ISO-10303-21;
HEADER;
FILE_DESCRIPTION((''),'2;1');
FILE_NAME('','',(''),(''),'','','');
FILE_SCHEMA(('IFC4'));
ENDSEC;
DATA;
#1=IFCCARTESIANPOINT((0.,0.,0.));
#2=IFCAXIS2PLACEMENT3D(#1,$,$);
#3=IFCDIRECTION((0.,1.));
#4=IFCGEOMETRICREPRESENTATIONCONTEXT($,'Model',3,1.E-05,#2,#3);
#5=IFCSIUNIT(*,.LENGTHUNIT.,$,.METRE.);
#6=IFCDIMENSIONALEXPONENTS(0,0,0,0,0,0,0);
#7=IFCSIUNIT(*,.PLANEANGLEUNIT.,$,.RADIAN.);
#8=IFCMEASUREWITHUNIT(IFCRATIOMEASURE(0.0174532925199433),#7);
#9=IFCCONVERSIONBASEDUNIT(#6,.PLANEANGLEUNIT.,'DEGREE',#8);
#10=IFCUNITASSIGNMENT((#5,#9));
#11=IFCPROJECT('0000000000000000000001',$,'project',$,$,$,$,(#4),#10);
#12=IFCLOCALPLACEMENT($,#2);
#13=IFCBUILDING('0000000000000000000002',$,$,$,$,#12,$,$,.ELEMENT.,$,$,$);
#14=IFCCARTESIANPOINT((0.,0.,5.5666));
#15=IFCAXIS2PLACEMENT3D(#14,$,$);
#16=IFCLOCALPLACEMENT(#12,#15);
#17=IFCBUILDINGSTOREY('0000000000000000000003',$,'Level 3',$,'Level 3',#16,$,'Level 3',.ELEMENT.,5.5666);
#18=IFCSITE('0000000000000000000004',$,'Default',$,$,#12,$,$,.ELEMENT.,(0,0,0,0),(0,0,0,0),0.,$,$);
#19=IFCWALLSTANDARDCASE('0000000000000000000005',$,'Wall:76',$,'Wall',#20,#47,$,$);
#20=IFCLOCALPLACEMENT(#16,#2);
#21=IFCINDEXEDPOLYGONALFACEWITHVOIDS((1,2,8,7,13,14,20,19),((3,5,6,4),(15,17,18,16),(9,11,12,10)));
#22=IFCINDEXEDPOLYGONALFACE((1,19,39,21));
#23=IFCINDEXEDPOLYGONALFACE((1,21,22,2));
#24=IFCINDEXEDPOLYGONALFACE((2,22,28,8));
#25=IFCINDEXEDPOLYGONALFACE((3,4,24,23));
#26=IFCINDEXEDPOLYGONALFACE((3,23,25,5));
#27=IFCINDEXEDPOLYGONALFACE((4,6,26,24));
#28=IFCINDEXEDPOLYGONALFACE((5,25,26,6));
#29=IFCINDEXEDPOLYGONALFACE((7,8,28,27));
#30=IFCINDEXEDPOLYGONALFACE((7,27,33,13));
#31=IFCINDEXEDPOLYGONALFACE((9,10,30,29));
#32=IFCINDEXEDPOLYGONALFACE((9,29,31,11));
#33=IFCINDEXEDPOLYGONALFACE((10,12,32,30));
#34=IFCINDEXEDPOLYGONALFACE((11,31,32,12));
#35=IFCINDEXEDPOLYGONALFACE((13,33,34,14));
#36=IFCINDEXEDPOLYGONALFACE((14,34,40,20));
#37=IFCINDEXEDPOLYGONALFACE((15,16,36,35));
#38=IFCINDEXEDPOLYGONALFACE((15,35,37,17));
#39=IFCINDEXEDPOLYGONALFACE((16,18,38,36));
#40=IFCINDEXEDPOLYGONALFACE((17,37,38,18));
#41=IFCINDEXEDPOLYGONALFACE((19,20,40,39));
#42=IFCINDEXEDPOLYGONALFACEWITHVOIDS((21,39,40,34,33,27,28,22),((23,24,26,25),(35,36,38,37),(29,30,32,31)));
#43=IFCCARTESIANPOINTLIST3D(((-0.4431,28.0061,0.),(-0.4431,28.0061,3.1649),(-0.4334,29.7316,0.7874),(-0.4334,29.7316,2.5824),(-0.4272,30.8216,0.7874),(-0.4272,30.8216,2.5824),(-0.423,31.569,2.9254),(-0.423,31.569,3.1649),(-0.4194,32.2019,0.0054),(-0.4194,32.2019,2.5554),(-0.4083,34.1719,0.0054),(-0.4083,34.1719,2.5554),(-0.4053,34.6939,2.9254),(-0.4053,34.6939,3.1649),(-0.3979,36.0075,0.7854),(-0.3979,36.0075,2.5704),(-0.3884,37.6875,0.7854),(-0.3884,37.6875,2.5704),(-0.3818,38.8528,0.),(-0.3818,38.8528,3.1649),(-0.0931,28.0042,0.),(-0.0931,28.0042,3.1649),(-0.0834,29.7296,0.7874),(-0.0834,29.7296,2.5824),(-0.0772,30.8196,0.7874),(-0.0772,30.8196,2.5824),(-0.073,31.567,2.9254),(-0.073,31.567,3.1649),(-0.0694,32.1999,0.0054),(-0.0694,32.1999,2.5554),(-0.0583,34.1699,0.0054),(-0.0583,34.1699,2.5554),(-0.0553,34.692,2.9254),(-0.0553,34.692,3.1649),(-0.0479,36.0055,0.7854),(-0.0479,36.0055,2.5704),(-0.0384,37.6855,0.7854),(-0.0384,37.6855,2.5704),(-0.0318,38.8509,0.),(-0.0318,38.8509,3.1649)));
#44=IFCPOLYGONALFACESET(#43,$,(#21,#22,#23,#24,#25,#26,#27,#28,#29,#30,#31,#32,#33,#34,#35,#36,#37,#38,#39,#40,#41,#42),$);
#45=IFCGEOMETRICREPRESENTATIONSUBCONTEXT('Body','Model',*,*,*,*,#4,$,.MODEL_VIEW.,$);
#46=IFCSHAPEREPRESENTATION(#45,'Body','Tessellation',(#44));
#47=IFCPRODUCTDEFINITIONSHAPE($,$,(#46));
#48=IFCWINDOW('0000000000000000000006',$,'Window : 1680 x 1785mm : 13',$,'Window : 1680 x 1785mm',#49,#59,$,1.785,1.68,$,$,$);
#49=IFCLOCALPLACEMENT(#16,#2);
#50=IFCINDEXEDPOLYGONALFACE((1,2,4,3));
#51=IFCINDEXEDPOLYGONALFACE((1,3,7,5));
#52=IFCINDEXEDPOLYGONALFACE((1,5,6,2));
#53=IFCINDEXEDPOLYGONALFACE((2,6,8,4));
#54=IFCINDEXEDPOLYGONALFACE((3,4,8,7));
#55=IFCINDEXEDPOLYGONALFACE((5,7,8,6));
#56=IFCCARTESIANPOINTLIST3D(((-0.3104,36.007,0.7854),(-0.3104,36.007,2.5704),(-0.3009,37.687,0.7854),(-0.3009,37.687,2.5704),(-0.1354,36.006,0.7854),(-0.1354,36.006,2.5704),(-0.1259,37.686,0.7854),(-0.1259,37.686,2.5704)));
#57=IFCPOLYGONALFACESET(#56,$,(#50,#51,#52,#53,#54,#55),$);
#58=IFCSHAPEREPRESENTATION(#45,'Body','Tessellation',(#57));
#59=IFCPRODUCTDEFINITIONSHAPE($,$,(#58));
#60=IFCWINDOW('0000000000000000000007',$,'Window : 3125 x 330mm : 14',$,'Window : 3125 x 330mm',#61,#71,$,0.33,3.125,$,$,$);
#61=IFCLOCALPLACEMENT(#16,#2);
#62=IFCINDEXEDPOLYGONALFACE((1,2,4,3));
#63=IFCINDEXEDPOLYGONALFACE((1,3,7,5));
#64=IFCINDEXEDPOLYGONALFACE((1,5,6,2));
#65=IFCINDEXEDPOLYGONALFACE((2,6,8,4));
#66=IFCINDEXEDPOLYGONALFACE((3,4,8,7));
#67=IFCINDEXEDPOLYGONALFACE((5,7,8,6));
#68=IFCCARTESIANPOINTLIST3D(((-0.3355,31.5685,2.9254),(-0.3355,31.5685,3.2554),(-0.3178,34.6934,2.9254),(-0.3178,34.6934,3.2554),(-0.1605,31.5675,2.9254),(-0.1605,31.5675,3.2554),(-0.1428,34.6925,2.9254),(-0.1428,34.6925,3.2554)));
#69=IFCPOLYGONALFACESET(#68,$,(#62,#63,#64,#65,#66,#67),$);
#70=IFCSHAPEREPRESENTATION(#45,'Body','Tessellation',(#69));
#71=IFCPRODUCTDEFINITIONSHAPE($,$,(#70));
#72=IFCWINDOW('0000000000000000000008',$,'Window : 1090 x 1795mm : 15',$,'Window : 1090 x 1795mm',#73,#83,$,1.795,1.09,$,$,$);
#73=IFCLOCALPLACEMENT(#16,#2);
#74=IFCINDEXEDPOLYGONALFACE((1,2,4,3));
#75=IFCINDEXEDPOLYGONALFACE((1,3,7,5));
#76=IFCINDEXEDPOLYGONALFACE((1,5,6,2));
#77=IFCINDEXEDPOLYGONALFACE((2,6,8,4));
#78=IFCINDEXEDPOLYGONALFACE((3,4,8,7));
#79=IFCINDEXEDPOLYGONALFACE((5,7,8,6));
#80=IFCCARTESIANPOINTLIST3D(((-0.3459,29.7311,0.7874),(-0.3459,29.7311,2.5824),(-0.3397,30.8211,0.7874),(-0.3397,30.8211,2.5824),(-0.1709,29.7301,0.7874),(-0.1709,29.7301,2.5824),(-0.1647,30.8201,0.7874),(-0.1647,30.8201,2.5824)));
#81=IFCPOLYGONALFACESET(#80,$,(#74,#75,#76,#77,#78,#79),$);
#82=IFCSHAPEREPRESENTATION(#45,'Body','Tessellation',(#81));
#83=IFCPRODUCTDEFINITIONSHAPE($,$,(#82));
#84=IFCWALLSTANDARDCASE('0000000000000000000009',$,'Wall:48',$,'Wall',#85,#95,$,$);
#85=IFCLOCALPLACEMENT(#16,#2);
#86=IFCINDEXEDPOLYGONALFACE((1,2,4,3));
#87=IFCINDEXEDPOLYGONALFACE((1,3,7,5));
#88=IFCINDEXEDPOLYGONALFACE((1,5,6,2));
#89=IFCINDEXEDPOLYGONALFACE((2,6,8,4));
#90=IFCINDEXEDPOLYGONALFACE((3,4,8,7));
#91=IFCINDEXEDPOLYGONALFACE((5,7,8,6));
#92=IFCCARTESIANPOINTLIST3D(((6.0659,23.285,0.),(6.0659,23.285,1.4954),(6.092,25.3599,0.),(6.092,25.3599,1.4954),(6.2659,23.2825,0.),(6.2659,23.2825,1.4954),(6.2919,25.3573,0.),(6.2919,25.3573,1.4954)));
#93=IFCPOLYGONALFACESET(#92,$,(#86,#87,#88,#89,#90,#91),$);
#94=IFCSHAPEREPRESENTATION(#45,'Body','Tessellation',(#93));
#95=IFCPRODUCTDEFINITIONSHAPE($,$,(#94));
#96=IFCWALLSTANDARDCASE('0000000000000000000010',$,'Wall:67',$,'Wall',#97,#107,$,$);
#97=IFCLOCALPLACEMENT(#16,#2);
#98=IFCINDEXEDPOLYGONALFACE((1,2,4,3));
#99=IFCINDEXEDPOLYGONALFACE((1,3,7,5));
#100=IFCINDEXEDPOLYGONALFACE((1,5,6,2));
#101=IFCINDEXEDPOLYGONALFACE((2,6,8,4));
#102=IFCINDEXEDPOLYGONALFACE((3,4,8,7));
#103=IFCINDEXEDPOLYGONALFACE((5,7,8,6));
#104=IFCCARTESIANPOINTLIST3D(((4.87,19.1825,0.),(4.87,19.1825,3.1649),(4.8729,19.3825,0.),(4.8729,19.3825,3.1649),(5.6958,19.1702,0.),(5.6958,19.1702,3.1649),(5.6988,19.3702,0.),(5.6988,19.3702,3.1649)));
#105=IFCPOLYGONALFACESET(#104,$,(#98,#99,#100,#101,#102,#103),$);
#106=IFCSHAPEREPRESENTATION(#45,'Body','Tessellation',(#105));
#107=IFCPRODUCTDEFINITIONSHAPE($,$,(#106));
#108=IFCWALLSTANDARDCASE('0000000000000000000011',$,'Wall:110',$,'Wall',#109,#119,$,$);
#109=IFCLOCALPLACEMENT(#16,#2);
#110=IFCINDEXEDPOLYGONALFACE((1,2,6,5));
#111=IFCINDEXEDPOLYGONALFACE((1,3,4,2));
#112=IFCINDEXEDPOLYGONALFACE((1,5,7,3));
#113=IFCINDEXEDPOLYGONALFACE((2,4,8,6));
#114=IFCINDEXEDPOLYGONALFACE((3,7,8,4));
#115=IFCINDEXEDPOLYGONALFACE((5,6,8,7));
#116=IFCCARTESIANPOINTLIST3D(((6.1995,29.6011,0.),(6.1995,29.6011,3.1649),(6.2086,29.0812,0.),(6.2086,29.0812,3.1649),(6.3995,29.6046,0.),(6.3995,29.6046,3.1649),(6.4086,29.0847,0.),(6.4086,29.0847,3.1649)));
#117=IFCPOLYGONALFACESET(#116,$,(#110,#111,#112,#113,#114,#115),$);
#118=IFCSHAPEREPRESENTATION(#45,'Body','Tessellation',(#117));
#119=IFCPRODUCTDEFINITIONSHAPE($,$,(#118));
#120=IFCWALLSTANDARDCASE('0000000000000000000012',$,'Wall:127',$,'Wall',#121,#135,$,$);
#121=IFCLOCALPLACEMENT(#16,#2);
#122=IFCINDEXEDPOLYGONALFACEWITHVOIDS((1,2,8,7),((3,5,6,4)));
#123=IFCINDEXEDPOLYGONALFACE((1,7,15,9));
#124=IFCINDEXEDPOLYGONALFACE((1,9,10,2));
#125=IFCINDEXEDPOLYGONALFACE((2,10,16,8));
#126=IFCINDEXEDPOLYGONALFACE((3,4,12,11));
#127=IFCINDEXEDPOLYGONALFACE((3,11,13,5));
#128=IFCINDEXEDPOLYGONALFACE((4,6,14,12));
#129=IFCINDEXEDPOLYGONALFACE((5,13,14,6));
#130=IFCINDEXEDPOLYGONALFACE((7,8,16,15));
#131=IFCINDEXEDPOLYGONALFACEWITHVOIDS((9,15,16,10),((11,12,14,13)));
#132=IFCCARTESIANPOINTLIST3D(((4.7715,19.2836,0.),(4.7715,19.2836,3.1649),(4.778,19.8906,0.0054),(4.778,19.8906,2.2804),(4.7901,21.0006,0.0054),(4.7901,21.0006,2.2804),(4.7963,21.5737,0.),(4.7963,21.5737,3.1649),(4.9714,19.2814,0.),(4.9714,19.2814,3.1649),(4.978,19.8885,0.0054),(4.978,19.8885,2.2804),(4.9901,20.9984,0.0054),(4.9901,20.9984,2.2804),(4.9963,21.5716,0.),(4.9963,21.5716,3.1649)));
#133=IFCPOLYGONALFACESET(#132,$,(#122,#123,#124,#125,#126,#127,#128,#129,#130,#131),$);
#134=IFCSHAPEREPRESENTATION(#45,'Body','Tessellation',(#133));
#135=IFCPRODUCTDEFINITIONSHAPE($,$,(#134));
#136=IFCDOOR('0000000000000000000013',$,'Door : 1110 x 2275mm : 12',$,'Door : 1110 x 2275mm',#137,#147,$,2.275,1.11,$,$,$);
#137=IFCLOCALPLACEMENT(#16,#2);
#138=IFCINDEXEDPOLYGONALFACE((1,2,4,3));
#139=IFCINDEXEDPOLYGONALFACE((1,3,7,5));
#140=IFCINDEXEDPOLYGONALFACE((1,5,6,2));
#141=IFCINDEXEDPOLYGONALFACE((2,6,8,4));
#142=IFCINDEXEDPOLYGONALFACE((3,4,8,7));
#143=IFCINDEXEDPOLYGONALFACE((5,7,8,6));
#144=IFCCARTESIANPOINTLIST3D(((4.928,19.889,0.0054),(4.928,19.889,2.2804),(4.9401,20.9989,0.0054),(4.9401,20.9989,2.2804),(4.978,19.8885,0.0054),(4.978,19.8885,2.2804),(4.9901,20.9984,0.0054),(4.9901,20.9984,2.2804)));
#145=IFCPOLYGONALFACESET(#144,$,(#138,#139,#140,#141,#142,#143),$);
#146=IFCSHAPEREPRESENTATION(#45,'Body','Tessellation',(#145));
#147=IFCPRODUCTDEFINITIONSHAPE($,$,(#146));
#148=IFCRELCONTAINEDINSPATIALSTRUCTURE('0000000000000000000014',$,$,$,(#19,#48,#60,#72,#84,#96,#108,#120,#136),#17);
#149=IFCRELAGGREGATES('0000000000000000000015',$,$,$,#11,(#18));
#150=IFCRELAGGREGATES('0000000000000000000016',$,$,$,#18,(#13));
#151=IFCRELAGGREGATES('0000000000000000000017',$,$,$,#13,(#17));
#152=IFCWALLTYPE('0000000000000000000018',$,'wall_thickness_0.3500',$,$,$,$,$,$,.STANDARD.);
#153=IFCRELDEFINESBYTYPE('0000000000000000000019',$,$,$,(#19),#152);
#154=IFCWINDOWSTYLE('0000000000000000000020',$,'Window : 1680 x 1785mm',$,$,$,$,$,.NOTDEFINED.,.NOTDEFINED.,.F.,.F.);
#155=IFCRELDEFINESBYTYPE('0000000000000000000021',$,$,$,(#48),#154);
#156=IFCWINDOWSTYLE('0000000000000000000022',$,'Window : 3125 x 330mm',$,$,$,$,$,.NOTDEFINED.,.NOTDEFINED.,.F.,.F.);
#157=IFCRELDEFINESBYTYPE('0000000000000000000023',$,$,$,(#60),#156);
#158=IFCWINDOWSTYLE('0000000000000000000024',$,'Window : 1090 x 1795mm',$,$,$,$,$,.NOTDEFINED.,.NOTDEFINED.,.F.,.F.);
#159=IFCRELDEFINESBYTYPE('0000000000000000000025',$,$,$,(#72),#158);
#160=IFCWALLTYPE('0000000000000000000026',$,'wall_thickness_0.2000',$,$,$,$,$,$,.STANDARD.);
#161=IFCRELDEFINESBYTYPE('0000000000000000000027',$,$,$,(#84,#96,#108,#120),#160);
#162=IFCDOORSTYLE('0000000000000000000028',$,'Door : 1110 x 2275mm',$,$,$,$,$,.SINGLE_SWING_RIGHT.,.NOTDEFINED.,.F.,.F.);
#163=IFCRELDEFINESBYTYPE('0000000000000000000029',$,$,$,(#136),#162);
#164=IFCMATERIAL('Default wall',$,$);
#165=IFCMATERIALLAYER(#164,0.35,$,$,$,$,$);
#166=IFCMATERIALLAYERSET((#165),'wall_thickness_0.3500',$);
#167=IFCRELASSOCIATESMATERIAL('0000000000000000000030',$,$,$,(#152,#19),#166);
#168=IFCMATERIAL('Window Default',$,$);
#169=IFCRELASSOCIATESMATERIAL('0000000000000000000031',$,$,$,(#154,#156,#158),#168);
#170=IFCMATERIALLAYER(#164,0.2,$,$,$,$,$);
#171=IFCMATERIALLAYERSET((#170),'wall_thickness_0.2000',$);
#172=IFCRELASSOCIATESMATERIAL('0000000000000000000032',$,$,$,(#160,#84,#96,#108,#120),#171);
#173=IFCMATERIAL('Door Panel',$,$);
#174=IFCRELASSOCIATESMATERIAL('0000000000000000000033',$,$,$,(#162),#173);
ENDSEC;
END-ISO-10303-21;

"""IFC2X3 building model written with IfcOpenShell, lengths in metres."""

from ifc_helpers import new_model, entity, si_unit, converted_unit, direction, frame, frame_2d, origin, origin_2d_with_axis, place, context, subcontext, project, spatial, polyline, rectangle, outline, extrude, source, transform, mapped, material, layer, layer_set, layer_usage, type_object, type_shapes, element, fill, save


model = new_model("IFC2X3")

# Units and contexts
model_context = context("Model", 3, precision=1e-05, world=origin(), true_north=direction((0.0, 1.0)))
body_context = subcontext(model_context, "Body", "Model", "MODEL_VIEW")
ifc_project = project(units=[si_unit("LENGTHUNIT", "METRE"), converted_unit("PLANEANGLEUNIT", "DEGREE", entity("IfcRatioMeasure", 0.0174532925199433), si_unit("PLANEANGLEUNIT", "RADIAN"), dimensions=[0, 0, 0, 0, 0, 0, 0])], contexts=[model_context])

# Site, building, storey
placement_1 = place(None, origin())
site = spatial("IfcSite", under=ifc_project, at=placement_1, Name="Default", CompositionType="ELEMENT", RefLatitude=(0, 0, 0, 0), RefLongitude=(0, 0, 0, 0), RefElevation=0.0)
building = spatial("IfcBuilding", under=site, at=placement_1, CompositionType="ELEMENT")
storey_placement = place(placement_1, frame((0.0, 0.0, 5.5666)))
storey = spatial("IfcBuildingStorey", under=building, at=storey_placement, Name="Level 3", ObjectType="Level 3", LongName="Level 3", CompositionType="ELEMENT", Elevation=5.5666)

# Shared definitions
ifc_material_1 = material(Name="Default wall")
ifc_material_2 = material(Name="Door Panel")

# Wall, openings, windows
ifc_layer_1 = layer(ifc_material_1, 0.35)
ifc_layer_set_1 = layer_set([ifc_layer_1], Name="wall_thickness_0.3500")
ifc_layer_usage_1 = layer_usage(ifc_layer_set_1, "AXIS2", "POSITIVE", -0.175)
wall_type_1 = type_object("IfcWallType", Name="wall_thickness_0.3500", PredefinedType="STANDARD", material=ifc_layer_set_1)
wall_1_placement = place(storey_placement, frame((-0.2068, 38.8518, 0.0), z_axis=(0.0, 0.0, 1.0), x_axis=(-0.005654, -0.999984, 0.0)))
wall_1 = element("IfcWallStandardCase", 1, at=wall_1_placement, inside=storey, type_object=wall_type_1, material=ifc_layer_usage_1, Name="Wall:76", ObjectType="Wall", context=body_context, shape_type="SweptSolid", body=[
    extrude(outline(polyline([(10.8469, -0.175), (10.8469, 0.175), (0.0, 0.175), (0.0, -0.175), (10.8469, -0.175)])), origin(), (0.0, 0.0, 1.0), 3.1649),
])
opening_1_placement = place(wall_1_placement, frame((4.681, -0.175, 0.0054)))
element("IfcOpeningElement", 2, at=opening_1_placement, cuts=wall_1, ObjectType="Opening", context=body_context, shape_type="SweptSolid", body=[
    extrude(rectangle(XDim=1.97, YDim=2.55, at=frame_2d((1.275, 0.985), x_axis=(0.0, 1.0))), frame((0.0, 0.0, 0.0), z_axis=(0.0, 1.0, 0.0), x_axis=(0.0, 0.0, 1.0)), (0.0, 0.0, 1.0), 0.35),
])
opening_2_placement = place(wall_1_placement, frame((1.1654, -0.175, 0.7854)))
opening_2 = element("IfcOpeningElement", 3, at=opening_2_placement, cuts=wall_1, ObjectType="Opening", context=body_context, shape_type="SweptSolid", body=[
    extrude(rectangle(XDim=1.68, YDim=1.785, at=frame_2d((0.8925, 0.84), x_axis=(0.0, 1.0))), frame((0.0, 0.0, 0.0), z_axis=(0.0, 1.0, 0.0), x_axis=(0.0, 0.0, 1.0)), (0.0, 0.0, 1.0), 0.35),
])
opening_3_placement = place(wall_1_placement, frame((4.159, -0.175, 2.9254)))
opening_3 = element("IfcOpeningElement", 4, at=opening_3_placement, cuts=wall_1, ObjectType="Opening", context=body_context, shape_type="SweptSolid", body=[
    extrude(rectangle(XDim=3.125, YDim=0.33, at=frame_2d((0.165, 1.5625), x_axis=(0.0, 1.0))), frame((0.0, 0.0, 0.0), z_axis=(0.0, 1.0, 0.0), x_axis=(0.0, 0.0, 1.0)), (0.0, 0.0, 1.0), 0.35),
])
opening_4_placement = place(wall_1_placement, frame((8.0314, -0.175, 0.7874)))
opening_4 = element("IfcOpeningElement", 5, at=opening_4_placement, cuts=wall_1, ObjectType="Opening", context=body_context, shape_type="SweptSolid", body=[
    extrude(rectangle(XDim=1.09, YDim=1.795, at=frame_2d((0.8975, 0.545), x_axis=(0.0, 1.0))), frame((0.0, 0.0, 0.0), z_axis=(0.0, 1.0, 0.0), x_axis=(0.0, 0.0, 1.0)), (0.0, 0.0, 1.0), 0.35),
])
ifc_material_3 = material(Name="Window Default")
window_style_1 = type_object("IfcWindowStyle", Name="Window : 1680 x 1785mm", ConstructionType="NOTDEFINED", OperationType="NOTDEFINED", ParameterTakesPrecedence=False, Sizeable=False, material=ifc_material_3)
shared_shape_1 = source(origin(), body_context, "Body", "SweptSolid", [
    extrude(rectangle(XDim=0.175, YDim=1.68, at=origin_2d_with_axis()), frame((0.84, 0.175, 0.0), z_axis=(0.0, 0.0, 1.0), x_axis=(0.0, 1.0, 0.0)), (0.0, 0.0, 1.0), 1.785),
])
type_shapes(window_style_1, [shared_shape_1])
window_1_placement = place(opening_2_placement, origin())
window_1 = element("IfcWindow", 6, at=window_1_placement, inside=storey, type_object=window_style_1, Name="Window : 1680 x 1785mm : 13", ObjectType="Window : 1680 x 1785mm", OverallHeight=1.785, OverallWidth=1.68, context=body_context, shape_type="MappedRepresentation", body=[
    mapped(shared_shape_1, transform((0.0, 0.0, 0.0), scale=1.0)),
])
fill(opening_2, window_1)
window_style_2 = type_object("IfcWindowStyle", Name="Window : 3125 x 330mm", ConstructionType="NOTDEFINED", OperationType="NOTDEFINED", ParameterTakesPrecedence=False, Sizeable=False, material=ifc_material_3)
shared_shape_2 = source(origin(), body_context, "Body", "SweptSolid", [
    extrude(rectangle(XDim=0.175, YDim=3.125, at=origin_2d_with_axis()), frame((1.5625, 0.175, 0.0), z_axis=(0.0, 0.0, 1.0), x_axis=(0.0, 1.0, 0.0)), (0.0, 0.0, 1.0), 0.33),
])
type_shapes(window_style_2, [shared_shape_2])
window_2_placement = place(opening_3_placement, origin())
window_2 = element("IfcWindow", 7, at=window_2_placement, inside=storey, type_object=window_style_2, Name="Window : 3125 x 330mm : 14", ObjectType="Window : 3125 x 330mm", OverallHeight=0.33, OverallWidth=3.125, context=body_context, shape_type="MappedRepresentation", body=[
    mapped(shared_shape_2, transform((0.0, 0.0, 0.0), scale=1.0)),
])
fill(opening_3, window_2)
window_style_3 = type_object("IfcWindowStyle", Name="Window : 1090 x 1795mm", ConstructionType="NOTDEFINED", OperationType="NOTDEFINED", ParameterTakesPrecedence=False, Sizeable=False, material=ifc_material_3)
shared_shape_3 = source(origin(), body_context, "Body", "SweptSolid", [
    extrude(rectangle(XDim=0.175, YDim=1.09, at=origin_2d_with_axis()), frame((0.545, 0.175, 0.0), z_axis=(0.0, 0.0, 1.0), x_axis=(0.0, 1.0, 0.0)), (0.0, 0.0, 1.0), 1.795),
])
type_shapes(window_style_3, [shared_shape_3])
window_3_placement = place(opening_4_placement, origin())
window_3 = element("IfcWindow", 8, at=window_3_placement, inside=storey, type_object=window_style_3, Name="Window : 1090 x 1795mm : 15", ObjectType="Window : 1090 x 1795mm", OverallHeight=1.795, OverallWidth=1.09, context=body_context, shape_type="MappedRepresentation", body=[
    mapped(shared_shape_3, transform((0.0, 0.0, 0.0), scale=1.0)),
])
fill(opening_4, window_3)

# Walls
ifc_layer_2 = layer(ifc_material_1, 0.2)
ifc_layer_set_2 = layer_set([ifc_layer_2], Name="wall_thickness_0.2000")
ifc_layer_usage_2 = layer_usage(ifc_layer_set_2, "AXIS2", "POSITIVE", -0.1)
wall_type_2 = type_object("IfcWallType", Name="wall_thickness_0.2000", PredefinedType="STANDARD", material=ifc_layer_set_2)
wall_2_placement = place(storey_placement, frame((6.1659, 23.2838, 0.0), z_axis=(0.0, 0.0, 1.0), x_axis=(0.012561, 0.999921, 0.0)))
element("IfcWallStandardCase", 9, at=wall_2_placement, inside=storey, type_object=wall_type_2, material=ifc_layer_usage_2, Name="Wall:48", ObjectType="Wall", context=body_context, shape_type="SweptSolid", body=[
    extrude(outline(polyline([(2.075, -0.1), (2.075, 0.1), (0.0, 0.1), (0.0, -0.1), (2.075, -0.1)])), origin(), (0.0, 0.0, 1.0), 1.4954),
])
wall_3_placement = place(storey_placement, frame((4.8714, 19.2825, 0.0), z_axis=(0.0, 0.0, 1.0), x_axis=(0.999888, -0.01496, 0.0)))
element("IfcWallStandardCase", 10, at=wall_3_placement, inside=storey, type_object=wall_type_2, material=ifc_layer_usage_2, Name="Wall:67", ObjectType="Wall", context=body_context, shape_type="SweptSolid", body=[
    extrude(outline(polyline([(0.8259, -0.1), (0.8259, 0.1), (0.0, 0.1), (0.0, -0.1), (0.8259, -0.1)])), origin(), (0.0, 0.0, 1.0), 3.1649),
])
wall_4_placement = place(storey_placement, frame((6.2995, 29.6029, 0.0), z_axis=(0.0, 0.0, 1.0), x_axis=(0.017456, -0.999848, 0.0)))
element("IfcWallStandardCase", 11, at=wall_4_placement, inside=storey, type_object=wall_type_2, material=ifc_layer_usage_2, Name="Wall:110", ObjectType="Wall", context=body_context, shape_type="SweptSolid", body=[
    extrude(outline(polyline([(0.52, -0.1), (0.52, 0.1), (0.0, 0.1), (0.0, -0.1), (0.52, -0.1)])), origin(), (0.0, 0.0, 1.0), 3.1649),
])

# Wall, opening, door
wall_5_placement = place(storey_placement, frame((4.8963, 21.5727, 0.0), z_axis=(0.0, 0.0, 1.0), x_axis=(-0.01084, -0.999941, 0.0)))
wall_5 = element("IfcWallStandardCase", 12, at=wall_5_placement, inside=storey, type_object=wall_type_2, material=ifc_layer_usage_2, Name="Wall:127", ObjectType="Wall", context=body_context, shape_type="SweptSolid", body=[
    extrude(outline(polyline([(2.2903, -0.1), (2.2903, 0.1), (0.0, 0.1), (0.0, -0.1), (2.2903, -0.1)])), origin(), (0.0, 0.0, 1.0), 3.1649),
])
opening_5_placement = place(wall_5_placement, frame((0.5732, -0.1, 0.0054)))
opening_5 = element("IfcOpeningElement", 13, at=opening_5_placement, cuts=wall_5, ObjectType="Opening", context=body_context, shape_type="SweptSolid", body=[
    extrude(rectangle(XDim=1.11, YDim=2.275, at=frame_2d((1.1375, 0.555), x_axis=(0.0, 1.0))), frame((0.0, 0.0, 0.0), z_axis=(0.0, 1.0, 0.0), x_axis=(0.0, 0.0, 1.0)), (0.0, 0.0, 1.0), 0.2),
])
door_style_1 = type_object("IfcDoorStyle", Name="Door : 1110 x 2275mm", ConstructionType="NOTDEFINED", OperationType="SINGLE_SWING_RIGHT", ParameterTakesPrecedence=False, Sizeable=False, material=ifc_material_2)
shared_shape_4 = source(origin(), body_context, "Body", "SweptSolid", [
    extrude(rectangle(XDim=0.05, YDim=1.11, at=origin_2d_with_axis()), frame((0.555, 0.175, 0.0), z_axis=(0.0, 0.0, 1.0), x_axis=(0.0, 1.0, 0.0)), (0.0, 0.0, 1.0), 2.275),
])
type_shapes(door_style_1, [shared_shape_4])
door_1_placement = place(opening_5_placement, origin())
door_1 = element("IfcDoor", 14, at=door_1_placement, inside=storey, type_object=door_style_1, Name="Door : 1110 x 2275mm : 12", ObjectType="Door : 1110 x 2275mm", OverallHeight=2.275, OverallWidth=1.11, context=body_context, shape_type="MappedRepresentation", body=[
    mapped(shared_shape_4, transform((0.0, 0.0, 0.0), scale=1.0)),
])
fill(opening_5, door_1)

save(model, "model.ifc")
